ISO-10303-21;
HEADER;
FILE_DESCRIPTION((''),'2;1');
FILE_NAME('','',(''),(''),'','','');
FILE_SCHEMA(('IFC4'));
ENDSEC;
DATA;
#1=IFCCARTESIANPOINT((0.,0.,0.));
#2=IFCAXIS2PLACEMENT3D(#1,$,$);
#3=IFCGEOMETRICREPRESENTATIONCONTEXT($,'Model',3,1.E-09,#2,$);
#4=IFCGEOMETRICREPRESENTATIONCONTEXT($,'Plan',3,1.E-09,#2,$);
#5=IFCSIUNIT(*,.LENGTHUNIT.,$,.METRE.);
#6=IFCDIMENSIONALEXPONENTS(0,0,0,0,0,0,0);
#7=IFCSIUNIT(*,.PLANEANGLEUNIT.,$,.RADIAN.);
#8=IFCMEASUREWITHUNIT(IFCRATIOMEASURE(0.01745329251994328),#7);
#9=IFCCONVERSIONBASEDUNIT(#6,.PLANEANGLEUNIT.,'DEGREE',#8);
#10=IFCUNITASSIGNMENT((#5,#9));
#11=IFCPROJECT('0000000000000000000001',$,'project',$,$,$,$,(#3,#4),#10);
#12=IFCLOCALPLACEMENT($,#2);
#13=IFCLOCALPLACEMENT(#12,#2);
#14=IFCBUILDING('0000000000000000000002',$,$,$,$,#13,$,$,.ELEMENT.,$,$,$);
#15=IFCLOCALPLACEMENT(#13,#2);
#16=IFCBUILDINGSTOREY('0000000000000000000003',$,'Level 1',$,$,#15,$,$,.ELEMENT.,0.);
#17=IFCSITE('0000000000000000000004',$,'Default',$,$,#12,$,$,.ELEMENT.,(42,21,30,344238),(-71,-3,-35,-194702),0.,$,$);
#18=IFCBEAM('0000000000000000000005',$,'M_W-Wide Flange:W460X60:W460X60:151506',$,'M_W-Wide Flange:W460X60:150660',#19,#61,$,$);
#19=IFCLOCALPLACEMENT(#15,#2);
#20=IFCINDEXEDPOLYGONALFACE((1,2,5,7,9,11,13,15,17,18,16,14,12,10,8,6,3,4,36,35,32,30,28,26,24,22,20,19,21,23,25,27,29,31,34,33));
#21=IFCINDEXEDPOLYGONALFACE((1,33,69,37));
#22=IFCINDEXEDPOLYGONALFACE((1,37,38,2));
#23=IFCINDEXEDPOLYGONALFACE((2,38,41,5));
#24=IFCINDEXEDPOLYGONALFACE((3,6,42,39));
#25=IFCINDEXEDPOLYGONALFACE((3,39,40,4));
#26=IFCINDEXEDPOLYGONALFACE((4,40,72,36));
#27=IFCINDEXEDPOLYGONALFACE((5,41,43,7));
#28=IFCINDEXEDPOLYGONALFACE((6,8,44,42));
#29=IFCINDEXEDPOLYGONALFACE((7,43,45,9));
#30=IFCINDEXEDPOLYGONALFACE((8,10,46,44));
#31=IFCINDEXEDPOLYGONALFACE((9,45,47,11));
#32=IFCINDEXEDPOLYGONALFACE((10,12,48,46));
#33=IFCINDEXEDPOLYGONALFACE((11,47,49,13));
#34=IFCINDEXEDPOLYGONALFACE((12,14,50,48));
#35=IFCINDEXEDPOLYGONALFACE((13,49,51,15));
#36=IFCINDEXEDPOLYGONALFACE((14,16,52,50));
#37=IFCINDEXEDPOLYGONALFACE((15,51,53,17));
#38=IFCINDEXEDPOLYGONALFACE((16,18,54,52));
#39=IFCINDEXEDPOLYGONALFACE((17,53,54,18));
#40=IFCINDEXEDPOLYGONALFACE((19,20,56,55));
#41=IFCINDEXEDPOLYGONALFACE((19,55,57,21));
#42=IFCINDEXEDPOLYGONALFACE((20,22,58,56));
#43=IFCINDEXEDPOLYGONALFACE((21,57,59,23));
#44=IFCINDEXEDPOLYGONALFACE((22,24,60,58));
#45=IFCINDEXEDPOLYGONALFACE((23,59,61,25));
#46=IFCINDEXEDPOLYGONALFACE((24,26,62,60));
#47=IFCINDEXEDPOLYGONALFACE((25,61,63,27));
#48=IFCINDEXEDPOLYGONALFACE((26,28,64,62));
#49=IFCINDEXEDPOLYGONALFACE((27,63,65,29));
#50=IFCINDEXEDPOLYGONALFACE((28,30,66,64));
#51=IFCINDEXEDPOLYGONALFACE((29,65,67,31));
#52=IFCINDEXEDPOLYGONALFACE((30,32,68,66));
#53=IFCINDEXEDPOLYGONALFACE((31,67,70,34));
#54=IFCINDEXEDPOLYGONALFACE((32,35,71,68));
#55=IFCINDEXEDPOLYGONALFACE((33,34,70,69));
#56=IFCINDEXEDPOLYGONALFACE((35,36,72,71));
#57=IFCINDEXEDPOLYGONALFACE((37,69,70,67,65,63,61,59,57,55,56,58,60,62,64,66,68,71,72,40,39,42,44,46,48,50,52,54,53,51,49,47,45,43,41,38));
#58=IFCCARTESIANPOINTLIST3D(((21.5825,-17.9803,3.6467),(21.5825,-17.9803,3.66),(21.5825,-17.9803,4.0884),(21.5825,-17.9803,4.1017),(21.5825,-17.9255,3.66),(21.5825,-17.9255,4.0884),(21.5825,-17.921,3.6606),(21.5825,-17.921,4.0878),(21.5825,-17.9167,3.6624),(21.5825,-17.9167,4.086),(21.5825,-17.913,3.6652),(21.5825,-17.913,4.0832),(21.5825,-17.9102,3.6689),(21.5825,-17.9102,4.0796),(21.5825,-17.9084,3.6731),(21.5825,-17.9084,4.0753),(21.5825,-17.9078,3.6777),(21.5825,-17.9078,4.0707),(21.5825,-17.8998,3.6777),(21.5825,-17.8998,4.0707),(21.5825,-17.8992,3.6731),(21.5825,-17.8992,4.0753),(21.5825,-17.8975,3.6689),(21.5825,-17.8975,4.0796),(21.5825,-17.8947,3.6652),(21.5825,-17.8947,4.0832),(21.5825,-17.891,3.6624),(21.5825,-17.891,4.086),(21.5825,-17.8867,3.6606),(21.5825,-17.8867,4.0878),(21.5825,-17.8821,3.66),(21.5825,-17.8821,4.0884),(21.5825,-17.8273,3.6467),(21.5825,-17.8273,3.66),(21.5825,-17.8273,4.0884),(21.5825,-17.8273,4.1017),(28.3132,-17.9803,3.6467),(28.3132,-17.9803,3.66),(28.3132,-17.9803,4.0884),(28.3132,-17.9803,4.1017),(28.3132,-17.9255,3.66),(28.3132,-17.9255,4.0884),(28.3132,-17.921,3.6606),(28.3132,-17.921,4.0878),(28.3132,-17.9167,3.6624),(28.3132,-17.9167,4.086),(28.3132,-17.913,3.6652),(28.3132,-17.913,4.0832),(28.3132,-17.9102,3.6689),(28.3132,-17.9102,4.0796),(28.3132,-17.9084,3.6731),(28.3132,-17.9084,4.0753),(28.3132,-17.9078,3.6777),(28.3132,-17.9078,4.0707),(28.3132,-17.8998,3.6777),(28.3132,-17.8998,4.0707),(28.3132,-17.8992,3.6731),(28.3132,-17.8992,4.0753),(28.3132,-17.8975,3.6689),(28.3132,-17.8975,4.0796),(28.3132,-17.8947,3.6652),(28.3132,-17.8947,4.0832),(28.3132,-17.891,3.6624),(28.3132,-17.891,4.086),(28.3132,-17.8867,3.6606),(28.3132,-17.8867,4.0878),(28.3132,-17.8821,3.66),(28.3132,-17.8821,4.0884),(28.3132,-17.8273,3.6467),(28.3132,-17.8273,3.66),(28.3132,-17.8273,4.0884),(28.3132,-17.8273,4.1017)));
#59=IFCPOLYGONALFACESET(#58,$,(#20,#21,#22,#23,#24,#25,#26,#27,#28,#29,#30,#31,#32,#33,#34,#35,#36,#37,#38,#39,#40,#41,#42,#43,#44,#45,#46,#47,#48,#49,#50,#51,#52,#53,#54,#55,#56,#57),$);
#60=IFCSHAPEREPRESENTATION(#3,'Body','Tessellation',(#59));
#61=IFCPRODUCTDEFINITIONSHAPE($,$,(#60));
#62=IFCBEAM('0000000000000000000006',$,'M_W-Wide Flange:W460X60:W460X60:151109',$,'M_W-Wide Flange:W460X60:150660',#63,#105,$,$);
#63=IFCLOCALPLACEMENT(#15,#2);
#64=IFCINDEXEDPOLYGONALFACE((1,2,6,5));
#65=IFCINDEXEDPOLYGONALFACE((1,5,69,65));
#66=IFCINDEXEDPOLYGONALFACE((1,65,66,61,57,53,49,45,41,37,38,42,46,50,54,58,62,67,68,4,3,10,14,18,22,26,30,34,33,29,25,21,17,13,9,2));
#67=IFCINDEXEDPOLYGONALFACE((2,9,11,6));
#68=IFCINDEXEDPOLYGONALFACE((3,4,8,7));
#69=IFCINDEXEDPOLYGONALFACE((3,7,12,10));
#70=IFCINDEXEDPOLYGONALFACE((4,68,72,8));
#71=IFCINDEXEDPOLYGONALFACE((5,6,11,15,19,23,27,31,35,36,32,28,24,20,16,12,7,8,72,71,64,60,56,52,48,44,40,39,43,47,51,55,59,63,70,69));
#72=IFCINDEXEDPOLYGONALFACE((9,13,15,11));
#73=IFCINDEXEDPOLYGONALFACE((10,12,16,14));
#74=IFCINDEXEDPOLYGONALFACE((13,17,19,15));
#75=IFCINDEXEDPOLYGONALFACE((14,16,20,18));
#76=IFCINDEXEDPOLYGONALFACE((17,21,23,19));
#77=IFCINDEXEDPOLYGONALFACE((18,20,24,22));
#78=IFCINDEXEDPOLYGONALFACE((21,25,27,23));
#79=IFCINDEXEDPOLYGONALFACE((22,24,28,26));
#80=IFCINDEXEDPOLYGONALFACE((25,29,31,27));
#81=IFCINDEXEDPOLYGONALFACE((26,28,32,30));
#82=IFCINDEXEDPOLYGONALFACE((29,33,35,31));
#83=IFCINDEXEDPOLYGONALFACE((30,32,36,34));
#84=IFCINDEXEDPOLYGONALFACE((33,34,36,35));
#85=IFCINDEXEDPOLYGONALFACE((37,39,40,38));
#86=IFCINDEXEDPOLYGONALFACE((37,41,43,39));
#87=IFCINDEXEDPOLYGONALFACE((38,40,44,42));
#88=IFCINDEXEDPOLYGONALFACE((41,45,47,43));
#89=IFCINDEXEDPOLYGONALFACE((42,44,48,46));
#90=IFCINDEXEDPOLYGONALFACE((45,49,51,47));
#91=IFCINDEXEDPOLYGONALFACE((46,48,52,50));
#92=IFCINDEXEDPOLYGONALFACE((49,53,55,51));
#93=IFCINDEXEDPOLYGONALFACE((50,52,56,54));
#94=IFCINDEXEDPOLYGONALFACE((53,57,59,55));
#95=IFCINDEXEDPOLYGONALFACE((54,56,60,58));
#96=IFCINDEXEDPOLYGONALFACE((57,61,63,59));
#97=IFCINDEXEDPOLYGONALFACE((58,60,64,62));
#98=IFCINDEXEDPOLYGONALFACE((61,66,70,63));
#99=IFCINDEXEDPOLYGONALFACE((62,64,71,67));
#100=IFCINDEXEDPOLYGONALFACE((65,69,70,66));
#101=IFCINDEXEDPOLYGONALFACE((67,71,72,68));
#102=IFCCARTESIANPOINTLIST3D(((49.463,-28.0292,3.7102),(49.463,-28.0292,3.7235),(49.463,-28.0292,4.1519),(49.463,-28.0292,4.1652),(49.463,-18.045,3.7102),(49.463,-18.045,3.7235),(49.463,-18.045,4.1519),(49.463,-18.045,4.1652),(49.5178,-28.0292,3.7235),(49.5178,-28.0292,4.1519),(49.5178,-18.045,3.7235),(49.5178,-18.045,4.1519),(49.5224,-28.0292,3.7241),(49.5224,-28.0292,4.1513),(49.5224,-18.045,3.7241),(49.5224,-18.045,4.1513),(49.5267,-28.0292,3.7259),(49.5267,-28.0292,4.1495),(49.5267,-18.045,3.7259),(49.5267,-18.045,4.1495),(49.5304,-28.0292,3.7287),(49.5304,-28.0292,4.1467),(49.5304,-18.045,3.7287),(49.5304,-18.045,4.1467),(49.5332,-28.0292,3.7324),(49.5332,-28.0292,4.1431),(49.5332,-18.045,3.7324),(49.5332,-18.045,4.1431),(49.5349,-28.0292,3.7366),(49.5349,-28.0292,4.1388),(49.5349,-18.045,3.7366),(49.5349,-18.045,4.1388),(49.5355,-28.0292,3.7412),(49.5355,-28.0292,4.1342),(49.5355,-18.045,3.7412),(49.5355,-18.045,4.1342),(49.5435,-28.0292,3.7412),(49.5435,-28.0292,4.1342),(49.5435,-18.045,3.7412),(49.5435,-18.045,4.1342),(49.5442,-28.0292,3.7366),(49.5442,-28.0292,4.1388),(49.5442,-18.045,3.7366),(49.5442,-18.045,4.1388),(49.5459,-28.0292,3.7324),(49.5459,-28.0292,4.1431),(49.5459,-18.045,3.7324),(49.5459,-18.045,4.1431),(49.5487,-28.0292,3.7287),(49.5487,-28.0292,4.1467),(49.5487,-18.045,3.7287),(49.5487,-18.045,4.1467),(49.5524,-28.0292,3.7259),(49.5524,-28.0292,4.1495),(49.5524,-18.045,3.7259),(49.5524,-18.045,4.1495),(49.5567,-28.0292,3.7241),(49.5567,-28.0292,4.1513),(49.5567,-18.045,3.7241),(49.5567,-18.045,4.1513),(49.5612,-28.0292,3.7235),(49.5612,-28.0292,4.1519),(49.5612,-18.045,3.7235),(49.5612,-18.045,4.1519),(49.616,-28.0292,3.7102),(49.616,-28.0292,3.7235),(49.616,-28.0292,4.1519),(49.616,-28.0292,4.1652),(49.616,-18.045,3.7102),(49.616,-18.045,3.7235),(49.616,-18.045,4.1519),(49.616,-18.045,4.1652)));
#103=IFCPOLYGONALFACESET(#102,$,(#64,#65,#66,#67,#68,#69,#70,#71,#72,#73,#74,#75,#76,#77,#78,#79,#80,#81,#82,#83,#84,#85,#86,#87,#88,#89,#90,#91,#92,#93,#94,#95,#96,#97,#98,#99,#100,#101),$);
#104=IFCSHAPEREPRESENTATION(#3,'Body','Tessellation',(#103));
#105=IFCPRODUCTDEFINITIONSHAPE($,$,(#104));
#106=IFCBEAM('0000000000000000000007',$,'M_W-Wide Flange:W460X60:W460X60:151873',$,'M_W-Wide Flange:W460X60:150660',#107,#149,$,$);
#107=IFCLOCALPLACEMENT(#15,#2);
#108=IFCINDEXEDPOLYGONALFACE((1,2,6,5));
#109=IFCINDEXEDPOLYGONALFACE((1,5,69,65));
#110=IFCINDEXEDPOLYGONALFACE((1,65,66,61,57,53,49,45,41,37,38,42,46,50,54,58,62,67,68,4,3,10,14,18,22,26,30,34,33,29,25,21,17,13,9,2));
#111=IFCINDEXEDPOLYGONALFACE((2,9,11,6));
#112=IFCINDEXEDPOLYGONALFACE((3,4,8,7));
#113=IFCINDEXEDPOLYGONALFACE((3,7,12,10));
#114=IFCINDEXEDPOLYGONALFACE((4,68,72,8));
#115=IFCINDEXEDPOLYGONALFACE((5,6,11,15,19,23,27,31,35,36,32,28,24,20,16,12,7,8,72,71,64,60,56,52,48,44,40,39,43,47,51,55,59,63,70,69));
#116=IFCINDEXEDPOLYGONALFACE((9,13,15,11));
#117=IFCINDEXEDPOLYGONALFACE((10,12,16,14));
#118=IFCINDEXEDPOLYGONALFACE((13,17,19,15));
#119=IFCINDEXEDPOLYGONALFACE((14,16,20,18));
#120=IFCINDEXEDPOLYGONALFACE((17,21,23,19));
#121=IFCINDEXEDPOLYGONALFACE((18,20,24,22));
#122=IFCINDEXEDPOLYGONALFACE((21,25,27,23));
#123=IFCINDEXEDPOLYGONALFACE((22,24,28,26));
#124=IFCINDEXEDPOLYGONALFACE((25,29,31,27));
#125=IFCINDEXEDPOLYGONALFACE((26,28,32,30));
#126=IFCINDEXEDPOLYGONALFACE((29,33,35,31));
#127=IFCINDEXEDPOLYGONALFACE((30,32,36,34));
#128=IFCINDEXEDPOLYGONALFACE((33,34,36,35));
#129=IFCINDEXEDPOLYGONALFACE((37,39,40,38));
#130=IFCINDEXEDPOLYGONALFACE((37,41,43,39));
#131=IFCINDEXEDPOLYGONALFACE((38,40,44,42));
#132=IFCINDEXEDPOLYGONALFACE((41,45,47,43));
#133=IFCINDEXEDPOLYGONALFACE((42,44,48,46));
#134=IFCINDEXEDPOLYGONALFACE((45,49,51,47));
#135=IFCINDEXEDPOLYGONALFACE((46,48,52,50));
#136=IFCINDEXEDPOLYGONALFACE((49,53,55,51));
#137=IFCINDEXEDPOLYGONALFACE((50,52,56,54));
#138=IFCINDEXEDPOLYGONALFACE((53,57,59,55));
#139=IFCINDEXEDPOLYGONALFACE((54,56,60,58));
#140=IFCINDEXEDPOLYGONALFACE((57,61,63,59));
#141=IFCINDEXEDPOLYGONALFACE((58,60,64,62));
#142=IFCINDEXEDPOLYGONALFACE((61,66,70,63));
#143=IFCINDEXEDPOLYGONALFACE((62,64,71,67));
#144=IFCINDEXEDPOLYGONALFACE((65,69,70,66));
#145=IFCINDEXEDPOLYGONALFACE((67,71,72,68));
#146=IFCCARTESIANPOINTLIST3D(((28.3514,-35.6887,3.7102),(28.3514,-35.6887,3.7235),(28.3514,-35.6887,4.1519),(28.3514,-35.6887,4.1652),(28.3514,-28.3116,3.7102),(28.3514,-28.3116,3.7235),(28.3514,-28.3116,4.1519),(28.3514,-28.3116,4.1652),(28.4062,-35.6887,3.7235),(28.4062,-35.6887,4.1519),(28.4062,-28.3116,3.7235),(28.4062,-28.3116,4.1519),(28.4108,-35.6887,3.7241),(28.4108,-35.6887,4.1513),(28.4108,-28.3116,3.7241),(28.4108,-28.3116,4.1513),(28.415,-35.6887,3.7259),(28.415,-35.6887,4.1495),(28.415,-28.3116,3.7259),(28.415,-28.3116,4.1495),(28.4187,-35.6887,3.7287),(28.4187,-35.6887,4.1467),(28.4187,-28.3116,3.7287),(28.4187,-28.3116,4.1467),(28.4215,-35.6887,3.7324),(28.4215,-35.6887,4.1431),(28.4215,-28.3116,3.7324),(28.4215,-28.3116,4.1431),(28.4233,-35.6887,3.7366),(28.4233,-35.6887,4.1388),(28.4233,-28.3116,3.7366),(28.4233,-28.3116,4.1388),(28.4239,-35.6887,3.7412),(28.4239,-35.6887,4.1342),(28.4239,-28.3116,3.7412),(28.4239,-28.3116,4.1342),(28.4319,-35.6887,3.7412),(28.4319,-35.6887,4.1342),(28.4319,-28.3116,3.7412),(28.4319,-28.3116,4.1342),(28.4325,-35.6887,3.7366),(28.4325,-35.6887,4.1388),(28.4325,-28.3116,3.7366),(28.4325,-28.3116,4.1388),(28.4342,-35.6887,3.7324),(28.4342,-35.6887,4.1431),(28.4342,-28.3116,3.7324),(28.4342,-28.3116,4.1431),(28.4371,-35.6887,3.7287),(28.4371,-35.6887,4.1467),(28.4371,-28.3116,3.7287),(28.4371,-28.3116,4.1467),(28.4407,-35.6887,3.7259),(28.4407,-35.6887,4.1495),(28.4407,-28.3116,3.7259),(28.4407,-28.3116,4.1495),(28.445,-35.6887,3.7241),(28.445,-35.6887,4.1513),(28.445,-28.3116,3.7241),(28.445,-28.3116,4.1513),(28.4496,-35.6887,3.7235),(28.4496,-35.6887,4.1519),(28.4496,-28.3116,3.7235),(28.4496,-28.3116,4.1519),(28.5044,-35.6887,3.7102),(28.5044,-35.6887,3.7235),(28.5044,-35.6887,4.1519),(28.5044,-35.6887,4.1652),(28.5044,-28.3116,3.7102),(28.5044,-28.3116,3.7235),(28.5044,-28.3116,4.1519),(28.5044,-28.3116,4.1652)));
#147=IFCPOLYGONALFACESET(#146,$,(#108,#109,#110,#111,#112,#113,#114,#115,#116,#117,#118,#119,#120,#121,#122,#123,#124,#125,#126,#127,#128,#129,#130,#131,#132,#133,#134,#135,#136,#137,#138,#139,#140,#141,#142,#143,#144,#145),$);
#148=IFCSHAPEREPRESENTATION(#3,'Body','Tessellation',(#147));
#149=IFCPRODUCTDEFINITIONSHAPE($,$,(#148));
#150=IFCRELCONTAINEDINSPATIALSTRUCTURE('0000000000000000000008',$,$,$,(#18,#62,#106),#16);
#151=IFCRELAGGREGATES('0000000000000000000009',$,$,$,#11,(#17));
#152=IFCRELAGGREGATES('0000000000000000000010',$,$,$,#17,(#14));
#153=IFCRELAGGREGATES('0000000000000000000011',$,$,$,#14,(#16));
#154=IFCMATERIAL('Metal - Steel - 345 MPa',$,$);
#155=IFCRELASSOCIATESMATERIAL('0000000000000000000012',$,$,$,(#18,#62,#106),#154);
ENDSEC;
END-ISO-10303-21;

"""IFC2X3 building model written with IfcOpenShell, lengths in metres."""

from ifc_helpers import new_model, entity, si_unit, converted_unit, frame, frame_2d, origin, place, context, project, spatial, polyline, circle_curve, parameter, trimmed, segment, composite_curve, outline, extrude, material, element, save


model = new_model("IFC2X3")

# Units and contexts
model_context = context("Model", 3, precision=1e-09, world=origin())
plan_context = context("Plan", 3, precision=1e-09, world=origin())
ifc_project = project(units=[si_unit("LENGTHUNIT", "METRE"), converted_unit("PLANEANGLEUNIT", "DEGREE", entity("IfcRatioMeasure", 0.01745329251994328), si_unit("PLANEANGLEUNIT", "RADIAN"), dimensions=[0, 0, 0, 0, 0, 0, 0])], contexts=[model_context, plan_context])

# Site, building, storey
site_placement = place(None, origin())
site = spatial("IfcSite", under=ifc_project, at=site_placement, Name="Default", CompositionType="ELEMENT", RefLatitude=(42, 21, 30, 344238), RefLongitude=(-71, -3, -35, -194702), RefElevation=0.0)
building_placement = place(site_placement, origin())
building = spatial("IfcBuilding", under=site, at=building_placement, CompositionType="ELEMENT")
storey_placement = place(building_placement, origin())
storey = spatial("IfcBuildingStorey", under=building, at=storey_placement, Name="Level 1", CompositionType="ELEMENT", Elevation=0.0)

# Beams
ifc_material = material(Name="Metal - Steel - 345 MPa")
beam_1_placement = place(storey_placement, frame((28.4279, -17.9038, 4.2672), z_axis=(0.0, 0.0, 1.0), x_axis=(0.0, 1.0, 0.0)))
element("IfcBeam", 1, at=beam_1_placement, inside=storey, material=ifc_material, Name="M_W-Wide Flange:W460X60:W460X60:151506", ObjectType="M_W-Wide Flange:W460X60:150660", context=model_context, shape_type="SweptSolid", body=[
    extrude(outline(composite_curve([segment(polyline([(0.2142, -0.0765), (0.2275, -0.0765)]), True, "CONTINUOUS"), segment(polyline([(0.2275, -0.0765), (0.2275, 0.0765)]), True, "CONTINUOUS"), segment(polyline([(0.2275, 0.0765), (0.2142, 0.0765)]), True, "CONTINUOUS"), segment(polyline([(0.2142, 0.0765), (0.2142, 0.0217)]), True, "CONTINUOUS"), segment(trimmed(circle_curve(frame_2d((0.1965, 0.0217), x_axis=(1.0, 0.0)), 0.0177), [parameter(270.0)], [parameter(360.0)], True, "PARAMETER"), False, "CONTINUOUS"), segment(polyline([(0.1965, 0.004), (-0.1965, 0.004)]), True, "CONTINUOUS"), segment(trimmed(circle_curve(frame_2d((-0.1965, 0.0217), x_axis=(0.0, -1.0)), 0.0177), [parameter(270.0)], [parameter(360.0)], True, "PARAMETER"), False, "CONTINUOUS"), segment(polyline([(-0.2142, 0.0217), (-0.2142, 0.0765)]), True, "CONTINUOUS"), segment(polyline([(-0.2142, 0.0765), (-0.2275, 0.0765)]), True, "CONTINUOUS"), segment(polyline([(-0.2275, 0.0765), (-0.2275, -0.0765)]), True, "CONTINUOUS"), segment(polyline([(-0.2275, -0.0765), (-0.2142, -0.0765)]), True, "CONTINUOUS"), segment(polyline([(-0.2142, -0.0765), (-0.2142, -0.0217)]), True, "CONTINUOUS"), segment(trimmed(circle_curve(frame_2d((-0.1965, -0.0217), x_axis=(-1.0, 0.0)), 0.0177), [parameter(270.0)], [parameter(360.0)], True, "PARAMETER"), False, "CONTINUOUS"), segment(polyline([(-0.1965, -0.004), (0.1965, -0.004)]), True, "CONTINUOUS"), segment(trimmed(circle_curve(frame_2d((0.1965, -0.0217), x_axis=(0.0, 1.0)), 0.0177), [parameter(270.0)], [parameter(0.0)], True, "PARAMETER"), False, "CONTINUOUS"), segment(polyline([(0.2142, -0.0217), (0.2142, -0.0765)]), True, "CONTINUOUS")], self_intersect=False)), frame((0.0, 6.8454, -0.393), z_axis=(0.0, -1.0, 0.0), x_axis=(0.0, 0.0, -1.0)), (0.0, 0.0, 1.0), 6.7307),
])
beam_2_placement = place(storey_placement, frame((49.5395, -17.9038, 4.2672), z_axis=(0.0, 0.0, 1.0), x_axis=(-1.0, 0.0, 0.0)))
element("IfcBeam", 2, at=beam_2_placement, inside=storey, material=ifc_material, Name="M_W-Wide Flange:W460X60:W460X60:151109", ObjectType="M_W-Wide Flange:W460X60:150660", context=model_context, shape_type="SweptSolid", body=[
    extrude(outline(composite_curve([segment(polyline([(0.2142, -0.0765), (0.2275, -0.0765)]), True, "CONTINUOUS"), segment(polyline([(0.2275, -0.0765), (0.2275, 0.0765)]), True, "CONTINUOUS"), segment(polyline([(0.2275, 0.0765), (0.2142, 0.0765)]), True, "CONTINUOUS"), segment(polyline([(0.2142, 0.0765), (0.2142, 0.0217)]), True, "CONTINUOUS"), segment(trimmed(circle_curve(frame_2d((0.1965, 0.0217), x_axis=(1.0, 0.0)), 0.0177), [parameter(270.0)], [parameter(360.0)], True, "PARAMETER"), False, "CONTINUOUS"), segment(polyline([(0.1965, 0.004), (-0.1965, 0.004)]), True, "CONTINUOUS"), segment(trimmed(circle_curve(frame_2d((-0.1965, 0.0217), x_axis=(0.0, -1.0)), 0.0177), [parameter(270.0)], [parameter(360.0)], True, "PARAMETER"), False, "CONTINUOUS"), segment(polyline([(-0.2142, 0.0217), (-0.2142, 0.0765)]), True, "CONTINUOUS"), segment(polyline([(-0.2142, 0.0765), (-0.2275, 0.0765)]), True, "CONTINUOUS"), segment(polyline([(-0.2275, 0.0765), (-0.2275, -0.0765)]), True, "CONTINUOUS"), segment(polyline([(-0.2275, -0.0765), (-0.2142, -0.0765)]), True, "CONTINUOUS"), segment(polyline([(-0.2142, -0.0765), (-0.2142, -0.0217)]), True, "CONTINUOUS"), segment(trimmed(circle_curve(frame_2d((-0.1965, -0.0217), x_axis=(-1.0, 0.0)), 0.0177), [parameter(270.0)], [parameter(360.0)], True, "PARAMETER"), False, "CONTINUOUS"), segment(polyline([(-0.1965, -0.004), (0.1965, -0.004)]), True, "CONTINUOUS"), segment(trimmed(circle_curve(frame_2d((0.1965, -0.0217), x_axis=(0.0, 1.0)), 0.0177), [parameter(270.0)], [parameter(0.0)], True, "PARAMETER"), False, "CONTINUOUS"), segment(polyline([(0.2142, -0.0217), (0.2142, -0.0765)]), True, "CONTINUOUS")], self_intersect=False)), frame((0.0, 10.1253, -0.3295), z_axis=(0.0, -1.0, 0.0), x_axis=(0.0, 0.0, -1.0)), (0.0, 0.0, 1.0), 9.9841),
])
beam_3_placement = place(storey_placement, frame((28.4279, -28.1704, 4.2672), z_axis=(0.0, 0.0, 1.0), x_axis=(-1.0, 0.0, 0.0)))
element("IfcBeam", 3, at=beam_3_placement, inside=storey, material=ifc_material, Name="M_W-Wide Flange:W460X60:W460X60:151873", ObjectType="M_W-Wide Flange:W460X60:150660", context=model_context, shape_type="SweptSolid", body=[
    extrude(outline(composite_curve([segment(polyline([(0.2142, -0.0765), (0.2275, -0.0765)]), True, "CONTINUOUS"), segment(polyline([(0.2275, -0.0765), (0.2275, 0.0765)]), True, "CONTINUOUS"), segment(polyline([(0.2275, 0.0765), (0.2142, 0.0765)]), True, "CONTINUOUS"), segment(polyline([(0.2142, 0.0765), (0.2142, 0.0217)]), True, "CONTINUOUS"), segment(trimmed(circle_curve(frame_2d((0.1965, 0.0217), x_axis=(1.0, 0.0)), 0.0177), [parameter(270.0)], [parameter(360.0)], True, "PARAMETER"), False, "CONTINUOUS"), segment(polyline([(0.1965, 0.004), (-0.1965, 0.004)]), True, "CONTINUOUS"), segment(trimmed(circle_curve(frame_2d((-0.1965, 0.0217), x_axis=(0.0, -1.0)), 0.0177), [parameter(270.0)], [parameter(360.0)], True, "PARAMETER"), False, "CONTINUOUS"), segment(polyline([(-0.2142, 0.0217), (-0.2142, 0.0765)]), True, "CONTINUOUS"), segment(polyline([(-0.2142, 0.0765), (-0.2275, 0.0765)]), True, "CONTINUOUS"), segment(polyline([(-0.2275, 0.0765), (-0.2275, -0.0765)]), True, "CONTINUOUS"), segment(polyline([(-0.2275, -0.0765), (-0.2142, -0.0765)]), True, "CONTINUOUS"), segment(polyline([(-0.2142, -0.0765), (-0.2142, -0.0217)]), True, "CONTINUOUS"), segment(trimmed(circle_curve(frame_2d((-0.1965, -0.0217), x_axis=(-1.0, 0.0)), 0.0177), [parameter(270.0)], [parameter(360.0)], True, "PARAMETER"), False, "CONTINUOUS"), segment(polyline([(-0.1965, -0.004), (0.1965, -0.004)]), True, "CONTINUOUS"), segment(trimmed(circle_curve(frame_2d((0.1965, -0.0217), x_axis=(0.0, 1.0)), 0.0177), [parameter(270.0)], [parameter(0.0)], True, "PARAMETER"), False, "CONTINUOUS"), segment(polyline([(0.2142, -0.0217), (0.2142, -0.0765)]), True, "CONTINUOUS")], self_intersect=False)), frame((0.0, 7.5183, -0.3295), z_axis=(0.0, -1.0, 0.0), x_axis=(0.0, 0.0, -1.0)), (0.0, 0.0, 1.0), 7.3771),
])

save(model, "model.ifc")
